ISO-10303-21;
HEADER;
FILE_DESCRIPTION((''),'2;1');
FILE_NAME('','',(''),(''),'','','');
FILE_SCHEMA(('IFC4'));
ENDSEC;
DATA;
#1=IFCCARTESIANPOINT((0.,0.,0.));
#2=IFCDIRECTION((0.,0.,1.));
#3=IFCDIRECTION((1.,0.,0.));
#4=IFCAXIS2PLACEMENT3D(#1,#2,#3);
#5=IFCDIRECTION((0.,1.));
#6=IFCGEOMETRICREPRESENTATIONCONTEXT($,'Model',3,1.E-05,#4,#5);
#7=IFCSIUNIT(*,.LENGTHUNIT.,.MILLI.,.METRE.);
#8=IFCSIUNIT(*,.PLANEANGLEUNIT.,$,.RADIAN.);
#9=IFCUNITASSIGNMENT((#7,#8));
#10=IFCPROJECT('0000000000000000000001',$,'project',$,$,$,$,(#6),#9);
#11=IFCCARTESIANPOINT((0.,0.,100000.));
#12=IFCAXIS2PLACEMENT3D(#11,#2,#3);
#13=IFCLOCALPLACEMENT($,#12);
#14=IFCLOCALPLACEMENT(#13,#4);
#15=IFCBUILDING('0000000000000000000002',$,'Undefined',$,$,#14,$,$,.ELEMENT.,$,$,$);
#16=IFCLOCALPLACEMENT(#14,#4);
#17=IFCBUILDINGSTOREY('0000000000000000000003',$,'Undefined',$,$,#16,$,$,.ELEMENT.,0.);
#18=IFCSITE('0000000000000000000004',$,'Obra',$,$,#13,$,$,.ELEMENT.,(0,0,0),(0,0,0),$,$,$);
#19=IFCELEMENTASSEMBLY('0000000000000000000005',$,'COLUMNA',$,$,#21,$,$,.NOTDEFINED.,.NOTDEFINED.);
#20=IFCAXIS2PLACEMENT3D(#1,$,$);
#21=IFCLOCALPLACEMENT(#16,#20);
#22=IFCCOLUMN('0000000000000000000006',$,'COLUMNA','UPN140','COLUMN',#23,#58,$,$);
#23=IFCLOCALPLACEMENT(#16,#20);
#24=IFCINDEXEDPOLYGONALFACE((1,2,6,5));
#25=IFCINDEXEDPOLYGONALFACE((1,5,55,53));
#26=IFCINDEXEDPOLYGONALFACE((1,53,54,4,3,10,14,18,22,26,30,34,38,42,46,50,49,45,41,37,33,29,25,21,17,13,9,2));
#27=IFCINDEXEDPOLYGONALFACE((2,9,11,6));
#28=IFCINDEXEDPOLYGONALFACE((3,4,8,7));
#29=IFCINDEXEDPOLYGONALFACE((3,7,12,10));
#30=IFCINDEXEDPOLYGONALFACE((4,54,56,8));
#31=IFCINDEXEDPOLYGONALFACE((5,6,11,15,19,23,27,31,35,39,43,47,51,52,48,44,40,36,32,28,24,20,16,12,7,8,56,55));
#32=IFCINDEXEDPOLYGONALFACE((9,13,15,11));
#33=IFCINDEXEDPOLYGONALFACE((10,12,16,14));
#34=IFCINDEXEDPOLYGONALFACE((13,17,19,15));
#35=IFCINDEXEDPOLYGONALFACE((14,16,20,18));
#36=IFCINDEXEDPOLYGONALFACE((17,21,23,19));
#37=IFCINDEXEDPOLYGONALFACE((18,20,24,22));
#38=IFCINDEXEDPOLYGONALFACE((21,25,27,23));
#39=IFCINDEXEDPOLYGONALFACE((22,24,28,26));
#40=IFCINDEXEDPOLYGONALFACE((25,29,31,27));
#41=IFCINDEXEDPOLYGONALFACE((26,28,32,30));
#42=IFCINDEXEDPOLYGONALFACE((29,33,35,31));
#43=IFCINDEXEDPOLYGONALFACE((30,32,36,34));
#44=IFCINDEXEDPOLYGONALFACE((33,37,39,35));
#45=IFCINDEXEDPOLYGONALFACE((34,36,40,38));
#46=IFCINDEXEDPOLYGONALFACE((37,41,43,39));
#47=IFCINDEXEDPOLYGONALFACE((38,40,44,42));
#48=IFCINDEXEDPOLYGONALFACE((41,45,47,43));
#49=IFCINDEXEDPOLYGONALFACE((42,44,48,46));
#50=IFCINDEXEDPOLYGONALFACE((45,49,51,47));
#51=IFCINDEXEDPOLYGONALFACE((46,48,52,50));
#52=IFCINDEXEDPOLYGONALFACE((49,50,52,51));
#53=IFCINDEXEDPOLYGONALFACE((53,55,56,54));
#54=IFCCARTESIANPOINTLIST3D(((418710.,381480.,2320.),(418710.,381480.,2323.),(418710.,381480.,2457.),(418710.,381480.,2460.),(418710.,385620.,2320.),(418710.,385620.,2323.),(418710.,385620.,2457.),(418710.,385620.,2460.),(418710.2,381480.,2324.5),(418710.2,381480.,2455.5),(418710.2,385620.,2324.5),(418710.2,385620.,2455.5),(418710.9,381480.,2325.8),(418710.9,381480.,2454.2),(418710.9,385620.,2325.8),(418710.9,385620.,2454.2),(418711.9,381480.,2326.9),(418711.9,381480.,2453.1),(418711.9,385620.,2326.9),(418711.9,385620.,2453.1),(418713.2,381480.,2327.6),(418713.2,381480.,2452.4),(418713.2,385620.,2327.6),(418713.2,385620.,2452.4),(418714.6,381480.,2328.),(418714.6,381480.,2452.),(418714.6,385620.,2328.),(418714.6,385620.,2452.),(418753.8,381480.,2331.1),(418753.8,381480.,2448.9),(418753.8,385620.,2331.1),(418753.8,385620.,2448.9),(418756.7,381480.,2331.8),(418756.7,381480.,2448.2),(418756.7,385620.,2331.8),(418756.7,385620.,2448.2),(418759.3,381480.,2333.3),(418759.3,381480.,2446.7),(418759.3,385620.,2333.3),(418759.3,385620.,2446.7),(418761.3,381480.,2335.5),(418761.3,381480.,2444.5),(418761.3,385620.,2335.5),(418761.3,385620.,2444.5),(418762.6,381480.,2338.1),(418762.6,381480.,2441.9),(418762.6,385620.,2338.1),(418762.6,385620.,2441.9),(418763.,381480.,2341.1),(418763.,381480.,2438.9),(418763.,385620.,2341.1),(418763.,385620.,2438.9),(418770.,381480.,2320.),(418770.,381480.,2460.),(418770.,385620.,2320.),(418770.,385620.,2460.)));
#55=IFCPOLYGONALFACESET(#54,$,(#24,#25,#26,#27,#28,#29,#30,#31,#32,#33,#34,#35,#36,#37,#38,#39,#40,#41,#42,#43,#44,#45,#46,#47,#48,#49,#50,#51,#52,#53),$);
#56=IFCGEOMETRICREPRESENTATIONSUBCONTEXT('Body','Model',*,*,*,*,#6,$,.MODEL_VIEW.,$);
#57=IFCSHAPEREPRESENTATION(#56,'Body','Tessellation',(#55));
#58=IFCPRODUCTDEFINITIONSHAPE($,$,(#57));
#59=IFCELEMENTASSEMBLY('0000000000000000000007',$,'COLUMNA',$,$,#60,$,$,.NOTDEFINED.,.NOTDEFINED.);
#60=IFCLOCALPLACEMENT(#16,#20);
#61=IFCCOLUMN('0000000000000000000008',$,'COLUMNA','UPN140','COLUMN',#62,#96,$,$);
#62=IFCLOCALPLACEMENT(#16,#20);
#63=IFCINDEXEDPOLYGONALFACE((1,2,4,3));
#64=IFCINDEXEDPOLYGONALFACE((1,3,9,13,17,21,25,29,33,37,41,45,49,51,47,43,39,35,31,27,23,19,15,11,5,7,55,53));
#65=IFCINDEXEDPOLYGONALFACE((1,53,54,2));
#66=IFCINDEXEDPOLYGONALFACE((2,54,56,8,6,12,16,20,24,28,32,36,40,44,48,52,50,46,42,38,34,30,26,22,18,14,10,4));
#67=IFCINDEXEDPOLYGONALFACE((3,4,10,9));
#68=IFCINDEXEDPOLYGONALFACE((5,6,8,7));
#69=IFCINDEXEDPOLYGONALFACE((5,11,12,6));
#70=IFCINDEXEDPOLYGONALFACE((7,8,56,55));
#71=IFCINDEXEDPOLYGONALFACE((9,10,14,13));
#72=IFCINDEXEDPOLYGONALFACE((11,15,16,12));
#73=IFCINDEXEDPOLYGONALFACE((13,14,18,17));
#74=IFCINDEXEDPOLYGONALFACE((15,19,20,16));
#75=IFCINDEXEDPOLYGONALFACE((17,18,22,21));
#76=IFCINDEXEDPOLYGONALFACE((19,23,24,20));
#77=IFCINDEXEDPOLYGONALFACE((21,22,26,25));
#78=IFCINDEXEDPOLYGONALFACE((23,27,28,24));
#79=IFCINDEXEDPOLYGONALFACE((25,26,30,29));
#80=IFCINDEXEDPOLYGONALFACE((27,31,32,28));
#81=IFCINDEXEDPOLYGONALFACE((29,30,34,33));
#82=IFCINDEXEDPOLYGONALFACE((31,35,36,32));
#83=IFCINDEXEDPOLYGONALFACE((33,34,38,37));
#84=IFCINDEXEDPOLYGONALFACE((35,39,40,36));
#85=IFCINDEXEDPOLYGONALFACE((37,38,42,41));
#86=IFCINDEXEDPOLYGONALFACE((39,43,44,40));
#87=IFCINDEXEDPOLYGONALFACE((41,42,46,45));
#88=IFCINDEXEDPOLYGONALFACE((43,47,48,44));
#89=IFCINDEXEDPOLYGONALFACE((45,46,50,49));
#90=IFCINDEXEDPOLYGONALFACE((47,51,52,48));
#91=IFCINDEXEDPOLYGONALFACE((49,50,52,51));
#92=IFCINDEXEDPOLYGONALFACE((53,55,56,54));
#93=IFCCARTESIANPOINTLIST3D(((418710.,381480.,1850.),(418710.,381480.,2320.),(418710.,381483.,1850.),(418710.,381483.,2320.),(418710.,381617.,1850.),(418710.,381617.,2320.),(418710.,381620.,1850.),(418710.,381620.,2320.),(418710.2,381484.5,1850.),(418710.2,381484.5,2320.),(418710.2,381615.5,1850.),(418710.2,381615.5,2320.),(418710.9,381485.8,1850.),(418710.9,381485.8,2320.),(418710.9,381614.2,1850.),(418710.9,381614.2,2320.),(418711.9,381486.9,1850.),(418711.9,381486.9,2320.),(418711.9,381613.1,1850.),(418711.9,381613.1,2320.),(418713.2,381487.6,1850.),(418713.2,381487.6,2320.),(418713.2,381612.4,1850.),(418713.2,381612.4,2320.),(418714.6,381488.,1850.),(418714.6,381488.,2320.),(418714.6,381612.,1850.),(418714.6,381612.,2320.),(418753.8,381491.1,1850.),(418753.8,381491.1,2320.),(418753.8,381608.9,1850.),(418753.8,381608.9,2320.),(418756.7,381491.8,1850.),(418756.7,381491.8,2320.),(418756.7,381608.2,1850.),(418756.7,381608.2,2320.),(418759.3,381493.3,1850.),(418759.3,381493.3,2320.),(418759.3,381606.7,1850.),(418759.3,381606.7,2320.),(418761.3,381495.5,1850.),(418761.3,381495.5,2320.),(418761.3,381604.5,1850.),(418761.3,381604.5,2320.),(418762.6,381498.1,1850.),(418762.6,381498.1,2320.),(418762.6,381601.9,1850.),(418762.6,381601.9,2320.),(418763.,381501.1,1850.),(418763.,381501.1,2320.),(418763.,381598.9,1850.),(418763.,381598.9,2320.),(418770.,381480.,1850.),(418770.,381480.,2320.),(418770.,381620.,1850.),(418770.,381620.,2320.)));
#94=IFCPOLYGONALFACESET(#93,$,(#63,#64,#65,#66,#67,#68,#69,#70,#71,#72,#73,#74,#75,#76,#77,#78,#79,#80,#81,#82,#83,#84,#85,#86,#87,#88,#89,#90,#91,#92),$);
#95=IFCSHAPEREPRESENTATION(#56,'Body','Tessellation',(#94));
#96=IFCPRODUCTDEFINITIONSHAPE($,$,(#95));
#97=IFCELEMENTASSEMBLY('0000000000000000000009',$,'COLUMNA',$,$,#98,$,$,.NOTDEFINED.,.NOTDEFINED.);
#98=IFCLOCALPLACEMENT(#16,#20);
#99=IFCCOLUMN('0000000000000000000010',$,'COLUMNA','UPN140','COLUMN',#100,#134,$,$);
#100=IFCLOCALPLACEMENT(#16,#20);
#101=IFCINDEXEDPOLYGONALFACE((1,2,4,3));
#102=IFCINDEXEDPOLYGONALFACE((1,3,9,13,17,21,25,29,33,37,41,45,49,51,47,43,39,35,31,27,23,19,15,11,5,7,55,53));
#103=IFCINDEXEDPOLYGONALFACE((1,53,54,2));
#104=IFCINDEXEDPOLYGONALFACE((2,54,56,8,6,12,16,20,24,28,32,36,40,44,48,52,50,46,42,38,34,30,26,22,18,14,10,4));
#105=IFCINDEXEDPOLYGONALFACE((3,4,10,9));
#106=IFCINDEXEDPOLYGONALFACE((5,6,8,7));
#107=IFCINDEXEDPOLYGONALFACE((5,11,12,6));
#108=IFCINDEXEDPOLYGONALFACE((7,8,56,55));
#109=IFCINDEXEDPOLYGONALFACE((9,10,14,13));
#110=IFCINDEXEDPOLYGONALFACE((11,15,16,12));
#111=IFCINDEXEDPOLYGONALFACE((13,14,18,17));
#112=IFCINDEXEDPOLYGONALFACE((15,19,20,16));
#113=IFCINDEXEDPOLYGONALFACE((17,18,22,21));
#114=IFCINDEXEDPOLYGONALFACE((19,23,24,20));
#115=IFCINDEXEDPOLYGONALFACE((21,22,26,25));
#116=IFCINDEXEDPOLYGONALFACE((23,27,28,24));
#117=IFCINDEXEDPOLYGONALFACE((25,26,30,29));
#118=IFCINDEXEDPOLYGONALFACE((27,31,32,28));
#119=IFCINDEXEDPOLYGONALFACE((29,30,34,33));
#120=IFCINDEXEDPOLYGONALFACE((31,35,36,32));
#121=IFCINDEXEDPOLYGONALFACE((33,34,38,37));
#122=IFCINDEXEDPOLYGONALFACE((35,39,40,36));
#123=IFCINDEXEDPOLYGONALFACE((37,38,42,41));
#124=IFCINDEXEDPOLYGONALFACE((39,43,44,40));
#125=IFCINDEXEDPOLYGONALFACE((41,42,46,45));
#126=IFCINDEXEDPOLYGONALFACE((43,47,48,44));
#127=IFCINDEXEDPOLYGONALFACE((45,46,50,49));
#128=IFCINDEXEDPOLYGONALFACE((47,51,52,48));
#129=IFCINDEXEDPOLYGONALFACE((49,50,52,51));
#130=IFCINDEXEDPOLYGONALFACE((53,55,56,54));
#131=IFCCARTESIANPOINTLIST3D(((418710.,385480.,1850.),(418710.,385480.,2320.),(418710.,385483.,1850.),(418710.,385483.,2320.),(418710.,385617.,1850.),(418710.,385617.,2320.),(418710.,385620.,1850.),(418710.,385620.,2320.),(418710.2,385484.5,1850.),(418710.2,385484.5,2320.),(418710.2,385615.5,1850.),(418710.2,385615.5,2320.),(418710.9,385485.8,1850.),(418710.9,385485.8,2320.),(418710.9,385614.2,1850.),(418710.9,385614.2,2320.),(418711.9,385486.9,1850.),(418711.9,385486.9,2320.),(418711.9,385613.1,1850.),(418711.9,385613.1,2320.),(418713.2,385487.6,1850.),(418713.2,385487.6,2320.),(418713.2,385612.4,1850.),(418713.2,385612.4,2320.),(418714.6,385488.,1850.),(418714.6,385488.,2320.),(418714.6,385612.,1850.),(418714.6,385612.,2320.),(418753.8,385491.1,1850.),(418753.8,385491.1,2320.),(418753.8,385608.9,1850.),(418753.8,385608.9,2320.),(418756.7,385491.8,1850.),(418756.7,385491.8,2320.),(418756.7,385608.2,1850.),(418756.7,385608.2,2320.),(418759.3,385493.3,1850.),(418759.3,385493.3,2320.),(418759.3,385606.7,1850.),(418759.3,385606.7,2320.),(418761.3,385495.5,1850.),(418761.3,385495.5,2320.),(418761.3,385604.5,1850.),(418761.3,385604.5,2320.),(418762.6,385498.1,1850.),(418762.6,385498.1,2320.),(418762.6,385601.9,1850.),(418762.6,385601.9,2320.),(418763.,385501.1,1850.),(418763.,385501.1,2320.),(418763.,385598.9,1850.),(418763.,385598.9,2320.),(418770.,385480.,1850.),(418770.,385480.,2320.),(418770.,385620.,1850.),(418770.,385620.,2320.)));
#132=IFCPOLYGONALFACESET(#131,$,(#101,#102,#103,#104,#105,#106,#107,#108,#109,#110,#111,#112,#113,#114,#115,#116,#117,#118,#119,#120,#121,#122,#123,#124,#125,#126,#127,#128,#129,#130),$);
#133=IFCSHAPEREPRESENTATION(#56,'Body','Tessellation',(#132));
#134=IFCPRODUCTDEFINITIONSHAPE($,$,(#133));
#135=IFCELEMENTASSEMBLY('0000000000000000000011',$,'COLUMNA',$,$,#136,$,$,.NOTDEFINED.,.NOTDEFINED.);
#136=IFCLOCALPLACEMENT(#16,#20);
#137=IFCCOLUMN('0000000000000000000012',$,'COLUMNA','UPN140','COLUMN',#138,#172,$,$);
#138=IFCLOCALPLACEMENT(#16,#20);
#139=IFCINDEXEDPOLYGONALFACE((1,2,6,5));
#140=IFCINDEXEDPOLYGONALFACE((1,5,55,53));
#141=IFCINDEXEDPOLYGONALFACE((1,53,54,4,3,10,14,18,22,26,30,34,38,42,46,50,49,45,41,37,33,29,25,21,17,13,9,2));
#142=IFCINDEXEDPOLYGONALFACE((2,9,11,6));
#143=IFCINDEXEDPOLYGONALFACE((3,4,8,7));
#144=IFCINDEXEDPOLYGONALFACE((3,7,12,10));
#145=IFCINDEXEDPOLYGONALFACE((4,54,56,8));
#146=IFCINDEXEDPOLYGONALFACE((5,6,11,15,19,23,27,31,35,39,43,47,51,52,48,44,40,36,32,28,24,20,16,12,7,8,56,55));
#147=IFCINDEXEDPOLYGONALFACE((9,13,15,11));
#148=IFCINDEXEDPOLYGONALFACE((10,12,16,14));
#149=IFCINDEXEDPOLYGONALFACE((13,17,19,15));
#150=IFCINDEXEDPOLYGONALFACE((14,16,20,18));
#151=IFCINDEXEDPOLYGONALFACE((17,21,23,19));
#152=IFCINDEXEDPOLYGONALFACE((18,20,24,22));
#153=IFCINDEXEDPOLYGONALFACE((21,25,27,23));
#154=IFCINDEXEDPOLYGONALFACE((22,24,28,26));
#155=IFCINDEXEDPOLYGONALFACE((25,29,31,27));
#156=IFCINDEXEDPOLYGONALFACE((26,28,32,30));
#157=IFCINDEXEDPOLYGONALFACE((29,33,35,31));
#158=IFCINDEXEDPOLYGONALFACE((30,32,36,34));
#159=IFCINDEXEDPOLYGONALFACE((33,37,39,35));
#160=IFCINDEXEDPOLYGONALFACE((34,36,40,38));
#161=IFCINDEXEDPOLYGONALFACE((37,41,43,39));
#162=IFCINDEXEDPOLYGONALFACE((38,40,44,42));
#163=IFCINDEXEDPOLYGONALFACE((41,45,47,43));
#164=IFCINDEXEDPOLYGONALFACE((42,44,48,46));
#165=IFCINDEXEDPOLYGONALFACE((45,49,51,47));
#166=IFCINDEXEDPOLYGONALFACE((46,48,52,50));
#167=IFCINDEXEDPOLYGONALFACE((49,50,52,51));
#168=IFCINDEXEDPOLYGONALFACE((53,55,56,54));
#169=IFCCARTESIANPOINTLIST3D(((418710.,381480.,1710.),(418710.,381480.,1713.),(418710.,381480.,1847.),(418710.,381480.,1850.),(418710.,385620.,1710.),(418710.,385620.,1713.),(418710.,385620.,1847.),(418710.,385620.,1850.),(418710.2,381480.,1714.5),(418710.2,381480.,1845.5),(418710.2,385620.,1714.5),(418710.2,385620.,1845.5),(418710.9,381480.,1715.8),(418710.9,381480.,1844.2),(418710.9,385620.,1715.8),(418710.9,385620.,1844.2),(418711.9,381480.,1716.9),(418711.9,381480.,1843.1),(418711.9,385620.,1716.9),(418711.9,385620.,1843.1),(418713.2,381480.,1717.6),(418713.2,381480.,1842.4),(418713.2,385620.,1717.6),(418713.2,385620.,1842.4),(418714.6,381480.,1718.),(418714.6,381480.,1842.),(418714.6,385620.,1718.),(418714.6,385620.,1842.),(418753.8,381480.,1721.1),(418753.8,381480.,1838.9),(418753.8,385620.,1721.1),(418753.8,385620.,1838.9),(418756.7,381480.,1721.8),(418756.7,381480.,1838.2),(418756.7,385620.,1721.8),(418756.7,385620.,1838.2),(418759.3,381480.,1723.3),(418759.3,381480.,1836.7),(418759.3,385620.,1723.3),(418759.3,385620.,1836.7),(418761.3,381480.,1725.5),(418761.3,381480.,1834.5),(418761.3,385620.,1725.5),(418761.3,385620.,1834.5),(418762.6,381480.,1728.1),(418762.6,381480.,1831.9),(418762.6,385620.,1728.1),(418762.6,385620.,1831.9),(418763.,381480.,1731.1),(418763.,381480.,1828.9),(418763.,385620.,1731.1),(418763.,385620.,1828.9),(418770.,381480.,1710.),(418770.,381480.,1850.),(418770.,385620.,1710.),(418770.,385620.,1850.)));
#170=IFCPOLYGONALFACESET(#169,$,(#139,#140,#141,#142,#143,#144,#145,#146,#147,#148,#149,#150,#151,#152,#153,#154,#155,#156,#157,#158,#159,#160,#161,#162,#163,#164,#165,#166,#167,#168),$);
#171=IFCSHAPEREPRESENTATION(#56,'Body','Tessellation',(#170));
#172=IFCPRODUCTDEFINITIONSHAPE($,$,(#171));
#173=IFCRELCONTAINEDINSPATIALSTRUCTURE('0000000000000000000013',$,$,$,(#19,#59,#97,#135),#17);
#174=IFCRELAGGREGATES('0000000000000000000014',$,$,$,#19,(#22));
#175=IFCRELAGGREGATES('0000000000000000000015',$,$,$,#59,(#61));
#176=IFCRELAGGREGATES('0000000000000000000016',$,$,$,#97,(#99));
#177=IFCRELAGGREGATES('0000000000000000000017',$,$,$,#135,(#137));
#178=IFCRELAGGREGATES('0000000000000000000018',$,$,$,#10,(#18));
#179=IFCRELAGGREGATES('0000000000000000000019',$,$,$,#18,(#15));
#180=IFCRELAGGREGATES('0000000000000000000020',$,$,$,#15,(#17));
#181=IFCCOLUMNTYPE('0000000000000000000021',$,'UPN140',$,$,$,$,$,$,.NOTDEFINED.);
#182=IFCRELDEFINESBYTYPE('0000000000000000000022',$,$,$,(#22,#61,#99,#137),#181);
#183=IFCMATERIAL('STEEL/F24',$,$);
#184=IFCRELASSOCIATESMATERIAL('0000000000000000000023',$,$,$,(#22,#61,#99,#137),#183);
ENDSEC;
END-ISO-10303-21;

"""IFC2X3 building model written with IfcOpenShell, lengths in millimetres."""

from ifc_helpers import new_model, si_unit, direction, frame, origin_with_axes, origin_2d_with_axis, place, context, subcontext, project, spatial, u_section, extrude, material, type_object, element, aggregate, save


model = new_model("IFC2X3")

# Units and contexts
model_context = context("Model", 3, precision=1e-05, world=origin_with_axes(), true_north=direction((0.0, 1.0)))
body_context = subcontext(model_context, "Body", "Model", "MODEL_VIEW")
ifc_project = project(units=[si_unit("LENGTHUNIT", "METRE", prefix="MILLI"), si_unit("PLANEANGLEUNIT", "RADIAN")], contexts=[model_context])

# Site, building, storey
site_placement = place(None, frame((0.0, 0.0, 100000.0), z_axis=(0.0, 0.0, 1.0), x_axis=(1.0, 0.0, 0.0)))
site = spatial("IfcSite", under=ifc_project, at=site_placement, Name="Obra", CompositionType="ELEMENT", RefLatitude=(0, 0, 0), RefLongitude=(0, 0, 0))
building_placement = place(site_placement, origin_with_axes())
building = spatial("IfcBuilding", under=site, at=building_placement, Name="Undefined", CompositionType="ELEMENT")
storey_placement = place(building_placement, origin_with_axes())
storey = spatial("IfcBuildingStorey", under=building, at=storey_placement, Name="Undefined", CompositionType="ELEMENT", Elevation=0.0)

# Element assemblies, columns
ifc_material_1 = material(Name="STEEL/F24")
column_type_1 = type_object("IfcColumnType", Name="UPN140", PredefinedType="NOTDEFINED")
assembly_1_placement = place(storey_placement, origin_with_axes())
assembly_1 = element("IfcElementAssembly", 1, at=assembly_1_placement, inside=storey, Name="COLUMNA", AssemblyPlace="NOTDEFINED", PredefinedType="NOTDEFINED")
column_1_placement = place(assembly_1_placement, frame((418740.0, 385620.0, 2390.0), z_axis=(0.0, -1.0, 0.0), x_axis=(0.0, 0.0, 1.0)))
column_1 = element("IfcColumn", 2, at=column_1_placement, type_object=column_type_1, material=ifc_material_1, Name="COLUMNA", Description="UPN140", ObjectType="COLUMN", context=body_context, shape_type="SweptSolid", body=[
    extrude(u_section(Depth=140.0, FlangeWidth=60.0, WebThickness=7.0, FlangeThickness=10.0, FilletRadius=10.0, EdgeRadius=5.0, FlangeSlope=0.07983, at=origin_2d_with_axis()), frame((0.0, 0.0, 4140.0), z_axis=(0.0, 0.0, -1.0), x_axis=(0.0, 1.0, 0.0)), (0.0, 0.0, 1.0), 4140.0),
])
aggregate(assembly_1, [column_1])
assembly_2_placement = place(storey_placement, origin_with_axes())
assembly_2 = element("IfcElementAssembly", 3, at=assembly_2_placement, inside=storey, Name="COLUMNA", AssemblyPlace="NOTDEFINED", PredefinedType="NOTDEFINED")
column_2_placement = place(assembly_2_placement, frame((418740.0, 381550.0, 1850.0), z_axis=(0.0, 0.0, 1.0), x_axis=(0.0, 1.0, 0.0)))
column_2 = element("IfcColumn", 4, at=column_2_placement, type_object=column_type_1, material=ifc_material_1, Name="COLUMNA", Description="UPN140", ObjectType="COLUMN", context=body_context, shape_type="SweptSolid", body=[
    extrude(u_section(Depth=140.0, FlangeWidth=60.0, WebThickness=7.0, FlangeThickness=10.0, FilletRadius=10.0, EdgeRadius=5.0, FlangeSlope=0.07983, at=origin_2d_with_axis()), frame((0.0, 0.0, 470.0), z_axis=(0.0, 0.0, -1.0), x_axis=(0.0, 1.0, 0.0)), (0.0, 0.0, 1.0), 470.0),
])
aggregate(assembly_2, [column_2])
assembly_3_placement = place(storey_placement, origin_with_axes())
assembly_3 = element("IfcElementAssembly", 5, at=assembly_3_placement, inside=storey, Name="COLUMNA", AssemblyPlace="NOTDEFINED", PredefinedType="NOTDEFINED")
column_3_placement = place(assembly_3_placement, frame((418740.0, 385550.0, 1850.0), z_axis=(0.0, 0.0, 1.0), x_axis=(0.0, 1.0, 0.0)))
column_3 = element("IfcColumn", 6, at=column_3_placement, type_object=column_type_1, material=ifc_material_1, Name="COLUMNA", Description="UPN140", ObjectType="COLUMN", context=body_context, shape_type="SweptSolid", body=[
    extrude(u_section(Depth=140.0, FlangeWidth=60.0, WebThickness=7.0, FlangeThickness=10.0, FilletRadius=10.0, EdgeRadius=5.0, FlangeSlope=0.07983, at=origin_2d_with_axis()), frame((0.0, 0.0, 470.0), z_axis=(0.0, 0.0, -1.0), x_axis=(0.0, 1.0, 0.0)), (0.0, 0.0, 1.0), 470.0),
])
aggregate(assembly_3, [column_3])
assembly_4_placement = place(storey_placement, origin_with_axes())
assembly_4 = element("IfcElementAssembly", 7, at=assembly_4_placement, inside=storey, Name="COLUMNA", AssemblyPlace="NOTDEFINED", PredefinedType="NOTDEFINED")
column_4_placement = place(assembly_4_placement, frame((418740.0, 385620.0, 1780.0), z_axis=(0.0, -1.0, 0.0), x_axis=(0.0, 0.0, 1.0)))
column_4 = element("IfcColumn", 8, at=column_4_placement, type_object=column_type_1, material=ifc_material_1, Name="COLUMNA", Description="UPN140", ObjectType="COLUMN", context=body_context, shape_type="SweptSolid", body=[
    extrude(u_section(Depth=140.0, FlangeWidth=60.0, WebThickness=7.0, FlangeThickness=10.0, FilletRadius=10.0, EdgeRadius=5.0, FlangeSlope=0.07983, at=origin_2d_with_axis()), frame((0.0, 0.0, 4140.0), z_axis=(0.0, 0.0, -1.0), x_axis=(0.0, 1.0, 0.0)), (0.0, 0.0, 1.0), 4140.0),
])
aggregate(assembly_4, [column_4])

save(model, "model.ifc")
